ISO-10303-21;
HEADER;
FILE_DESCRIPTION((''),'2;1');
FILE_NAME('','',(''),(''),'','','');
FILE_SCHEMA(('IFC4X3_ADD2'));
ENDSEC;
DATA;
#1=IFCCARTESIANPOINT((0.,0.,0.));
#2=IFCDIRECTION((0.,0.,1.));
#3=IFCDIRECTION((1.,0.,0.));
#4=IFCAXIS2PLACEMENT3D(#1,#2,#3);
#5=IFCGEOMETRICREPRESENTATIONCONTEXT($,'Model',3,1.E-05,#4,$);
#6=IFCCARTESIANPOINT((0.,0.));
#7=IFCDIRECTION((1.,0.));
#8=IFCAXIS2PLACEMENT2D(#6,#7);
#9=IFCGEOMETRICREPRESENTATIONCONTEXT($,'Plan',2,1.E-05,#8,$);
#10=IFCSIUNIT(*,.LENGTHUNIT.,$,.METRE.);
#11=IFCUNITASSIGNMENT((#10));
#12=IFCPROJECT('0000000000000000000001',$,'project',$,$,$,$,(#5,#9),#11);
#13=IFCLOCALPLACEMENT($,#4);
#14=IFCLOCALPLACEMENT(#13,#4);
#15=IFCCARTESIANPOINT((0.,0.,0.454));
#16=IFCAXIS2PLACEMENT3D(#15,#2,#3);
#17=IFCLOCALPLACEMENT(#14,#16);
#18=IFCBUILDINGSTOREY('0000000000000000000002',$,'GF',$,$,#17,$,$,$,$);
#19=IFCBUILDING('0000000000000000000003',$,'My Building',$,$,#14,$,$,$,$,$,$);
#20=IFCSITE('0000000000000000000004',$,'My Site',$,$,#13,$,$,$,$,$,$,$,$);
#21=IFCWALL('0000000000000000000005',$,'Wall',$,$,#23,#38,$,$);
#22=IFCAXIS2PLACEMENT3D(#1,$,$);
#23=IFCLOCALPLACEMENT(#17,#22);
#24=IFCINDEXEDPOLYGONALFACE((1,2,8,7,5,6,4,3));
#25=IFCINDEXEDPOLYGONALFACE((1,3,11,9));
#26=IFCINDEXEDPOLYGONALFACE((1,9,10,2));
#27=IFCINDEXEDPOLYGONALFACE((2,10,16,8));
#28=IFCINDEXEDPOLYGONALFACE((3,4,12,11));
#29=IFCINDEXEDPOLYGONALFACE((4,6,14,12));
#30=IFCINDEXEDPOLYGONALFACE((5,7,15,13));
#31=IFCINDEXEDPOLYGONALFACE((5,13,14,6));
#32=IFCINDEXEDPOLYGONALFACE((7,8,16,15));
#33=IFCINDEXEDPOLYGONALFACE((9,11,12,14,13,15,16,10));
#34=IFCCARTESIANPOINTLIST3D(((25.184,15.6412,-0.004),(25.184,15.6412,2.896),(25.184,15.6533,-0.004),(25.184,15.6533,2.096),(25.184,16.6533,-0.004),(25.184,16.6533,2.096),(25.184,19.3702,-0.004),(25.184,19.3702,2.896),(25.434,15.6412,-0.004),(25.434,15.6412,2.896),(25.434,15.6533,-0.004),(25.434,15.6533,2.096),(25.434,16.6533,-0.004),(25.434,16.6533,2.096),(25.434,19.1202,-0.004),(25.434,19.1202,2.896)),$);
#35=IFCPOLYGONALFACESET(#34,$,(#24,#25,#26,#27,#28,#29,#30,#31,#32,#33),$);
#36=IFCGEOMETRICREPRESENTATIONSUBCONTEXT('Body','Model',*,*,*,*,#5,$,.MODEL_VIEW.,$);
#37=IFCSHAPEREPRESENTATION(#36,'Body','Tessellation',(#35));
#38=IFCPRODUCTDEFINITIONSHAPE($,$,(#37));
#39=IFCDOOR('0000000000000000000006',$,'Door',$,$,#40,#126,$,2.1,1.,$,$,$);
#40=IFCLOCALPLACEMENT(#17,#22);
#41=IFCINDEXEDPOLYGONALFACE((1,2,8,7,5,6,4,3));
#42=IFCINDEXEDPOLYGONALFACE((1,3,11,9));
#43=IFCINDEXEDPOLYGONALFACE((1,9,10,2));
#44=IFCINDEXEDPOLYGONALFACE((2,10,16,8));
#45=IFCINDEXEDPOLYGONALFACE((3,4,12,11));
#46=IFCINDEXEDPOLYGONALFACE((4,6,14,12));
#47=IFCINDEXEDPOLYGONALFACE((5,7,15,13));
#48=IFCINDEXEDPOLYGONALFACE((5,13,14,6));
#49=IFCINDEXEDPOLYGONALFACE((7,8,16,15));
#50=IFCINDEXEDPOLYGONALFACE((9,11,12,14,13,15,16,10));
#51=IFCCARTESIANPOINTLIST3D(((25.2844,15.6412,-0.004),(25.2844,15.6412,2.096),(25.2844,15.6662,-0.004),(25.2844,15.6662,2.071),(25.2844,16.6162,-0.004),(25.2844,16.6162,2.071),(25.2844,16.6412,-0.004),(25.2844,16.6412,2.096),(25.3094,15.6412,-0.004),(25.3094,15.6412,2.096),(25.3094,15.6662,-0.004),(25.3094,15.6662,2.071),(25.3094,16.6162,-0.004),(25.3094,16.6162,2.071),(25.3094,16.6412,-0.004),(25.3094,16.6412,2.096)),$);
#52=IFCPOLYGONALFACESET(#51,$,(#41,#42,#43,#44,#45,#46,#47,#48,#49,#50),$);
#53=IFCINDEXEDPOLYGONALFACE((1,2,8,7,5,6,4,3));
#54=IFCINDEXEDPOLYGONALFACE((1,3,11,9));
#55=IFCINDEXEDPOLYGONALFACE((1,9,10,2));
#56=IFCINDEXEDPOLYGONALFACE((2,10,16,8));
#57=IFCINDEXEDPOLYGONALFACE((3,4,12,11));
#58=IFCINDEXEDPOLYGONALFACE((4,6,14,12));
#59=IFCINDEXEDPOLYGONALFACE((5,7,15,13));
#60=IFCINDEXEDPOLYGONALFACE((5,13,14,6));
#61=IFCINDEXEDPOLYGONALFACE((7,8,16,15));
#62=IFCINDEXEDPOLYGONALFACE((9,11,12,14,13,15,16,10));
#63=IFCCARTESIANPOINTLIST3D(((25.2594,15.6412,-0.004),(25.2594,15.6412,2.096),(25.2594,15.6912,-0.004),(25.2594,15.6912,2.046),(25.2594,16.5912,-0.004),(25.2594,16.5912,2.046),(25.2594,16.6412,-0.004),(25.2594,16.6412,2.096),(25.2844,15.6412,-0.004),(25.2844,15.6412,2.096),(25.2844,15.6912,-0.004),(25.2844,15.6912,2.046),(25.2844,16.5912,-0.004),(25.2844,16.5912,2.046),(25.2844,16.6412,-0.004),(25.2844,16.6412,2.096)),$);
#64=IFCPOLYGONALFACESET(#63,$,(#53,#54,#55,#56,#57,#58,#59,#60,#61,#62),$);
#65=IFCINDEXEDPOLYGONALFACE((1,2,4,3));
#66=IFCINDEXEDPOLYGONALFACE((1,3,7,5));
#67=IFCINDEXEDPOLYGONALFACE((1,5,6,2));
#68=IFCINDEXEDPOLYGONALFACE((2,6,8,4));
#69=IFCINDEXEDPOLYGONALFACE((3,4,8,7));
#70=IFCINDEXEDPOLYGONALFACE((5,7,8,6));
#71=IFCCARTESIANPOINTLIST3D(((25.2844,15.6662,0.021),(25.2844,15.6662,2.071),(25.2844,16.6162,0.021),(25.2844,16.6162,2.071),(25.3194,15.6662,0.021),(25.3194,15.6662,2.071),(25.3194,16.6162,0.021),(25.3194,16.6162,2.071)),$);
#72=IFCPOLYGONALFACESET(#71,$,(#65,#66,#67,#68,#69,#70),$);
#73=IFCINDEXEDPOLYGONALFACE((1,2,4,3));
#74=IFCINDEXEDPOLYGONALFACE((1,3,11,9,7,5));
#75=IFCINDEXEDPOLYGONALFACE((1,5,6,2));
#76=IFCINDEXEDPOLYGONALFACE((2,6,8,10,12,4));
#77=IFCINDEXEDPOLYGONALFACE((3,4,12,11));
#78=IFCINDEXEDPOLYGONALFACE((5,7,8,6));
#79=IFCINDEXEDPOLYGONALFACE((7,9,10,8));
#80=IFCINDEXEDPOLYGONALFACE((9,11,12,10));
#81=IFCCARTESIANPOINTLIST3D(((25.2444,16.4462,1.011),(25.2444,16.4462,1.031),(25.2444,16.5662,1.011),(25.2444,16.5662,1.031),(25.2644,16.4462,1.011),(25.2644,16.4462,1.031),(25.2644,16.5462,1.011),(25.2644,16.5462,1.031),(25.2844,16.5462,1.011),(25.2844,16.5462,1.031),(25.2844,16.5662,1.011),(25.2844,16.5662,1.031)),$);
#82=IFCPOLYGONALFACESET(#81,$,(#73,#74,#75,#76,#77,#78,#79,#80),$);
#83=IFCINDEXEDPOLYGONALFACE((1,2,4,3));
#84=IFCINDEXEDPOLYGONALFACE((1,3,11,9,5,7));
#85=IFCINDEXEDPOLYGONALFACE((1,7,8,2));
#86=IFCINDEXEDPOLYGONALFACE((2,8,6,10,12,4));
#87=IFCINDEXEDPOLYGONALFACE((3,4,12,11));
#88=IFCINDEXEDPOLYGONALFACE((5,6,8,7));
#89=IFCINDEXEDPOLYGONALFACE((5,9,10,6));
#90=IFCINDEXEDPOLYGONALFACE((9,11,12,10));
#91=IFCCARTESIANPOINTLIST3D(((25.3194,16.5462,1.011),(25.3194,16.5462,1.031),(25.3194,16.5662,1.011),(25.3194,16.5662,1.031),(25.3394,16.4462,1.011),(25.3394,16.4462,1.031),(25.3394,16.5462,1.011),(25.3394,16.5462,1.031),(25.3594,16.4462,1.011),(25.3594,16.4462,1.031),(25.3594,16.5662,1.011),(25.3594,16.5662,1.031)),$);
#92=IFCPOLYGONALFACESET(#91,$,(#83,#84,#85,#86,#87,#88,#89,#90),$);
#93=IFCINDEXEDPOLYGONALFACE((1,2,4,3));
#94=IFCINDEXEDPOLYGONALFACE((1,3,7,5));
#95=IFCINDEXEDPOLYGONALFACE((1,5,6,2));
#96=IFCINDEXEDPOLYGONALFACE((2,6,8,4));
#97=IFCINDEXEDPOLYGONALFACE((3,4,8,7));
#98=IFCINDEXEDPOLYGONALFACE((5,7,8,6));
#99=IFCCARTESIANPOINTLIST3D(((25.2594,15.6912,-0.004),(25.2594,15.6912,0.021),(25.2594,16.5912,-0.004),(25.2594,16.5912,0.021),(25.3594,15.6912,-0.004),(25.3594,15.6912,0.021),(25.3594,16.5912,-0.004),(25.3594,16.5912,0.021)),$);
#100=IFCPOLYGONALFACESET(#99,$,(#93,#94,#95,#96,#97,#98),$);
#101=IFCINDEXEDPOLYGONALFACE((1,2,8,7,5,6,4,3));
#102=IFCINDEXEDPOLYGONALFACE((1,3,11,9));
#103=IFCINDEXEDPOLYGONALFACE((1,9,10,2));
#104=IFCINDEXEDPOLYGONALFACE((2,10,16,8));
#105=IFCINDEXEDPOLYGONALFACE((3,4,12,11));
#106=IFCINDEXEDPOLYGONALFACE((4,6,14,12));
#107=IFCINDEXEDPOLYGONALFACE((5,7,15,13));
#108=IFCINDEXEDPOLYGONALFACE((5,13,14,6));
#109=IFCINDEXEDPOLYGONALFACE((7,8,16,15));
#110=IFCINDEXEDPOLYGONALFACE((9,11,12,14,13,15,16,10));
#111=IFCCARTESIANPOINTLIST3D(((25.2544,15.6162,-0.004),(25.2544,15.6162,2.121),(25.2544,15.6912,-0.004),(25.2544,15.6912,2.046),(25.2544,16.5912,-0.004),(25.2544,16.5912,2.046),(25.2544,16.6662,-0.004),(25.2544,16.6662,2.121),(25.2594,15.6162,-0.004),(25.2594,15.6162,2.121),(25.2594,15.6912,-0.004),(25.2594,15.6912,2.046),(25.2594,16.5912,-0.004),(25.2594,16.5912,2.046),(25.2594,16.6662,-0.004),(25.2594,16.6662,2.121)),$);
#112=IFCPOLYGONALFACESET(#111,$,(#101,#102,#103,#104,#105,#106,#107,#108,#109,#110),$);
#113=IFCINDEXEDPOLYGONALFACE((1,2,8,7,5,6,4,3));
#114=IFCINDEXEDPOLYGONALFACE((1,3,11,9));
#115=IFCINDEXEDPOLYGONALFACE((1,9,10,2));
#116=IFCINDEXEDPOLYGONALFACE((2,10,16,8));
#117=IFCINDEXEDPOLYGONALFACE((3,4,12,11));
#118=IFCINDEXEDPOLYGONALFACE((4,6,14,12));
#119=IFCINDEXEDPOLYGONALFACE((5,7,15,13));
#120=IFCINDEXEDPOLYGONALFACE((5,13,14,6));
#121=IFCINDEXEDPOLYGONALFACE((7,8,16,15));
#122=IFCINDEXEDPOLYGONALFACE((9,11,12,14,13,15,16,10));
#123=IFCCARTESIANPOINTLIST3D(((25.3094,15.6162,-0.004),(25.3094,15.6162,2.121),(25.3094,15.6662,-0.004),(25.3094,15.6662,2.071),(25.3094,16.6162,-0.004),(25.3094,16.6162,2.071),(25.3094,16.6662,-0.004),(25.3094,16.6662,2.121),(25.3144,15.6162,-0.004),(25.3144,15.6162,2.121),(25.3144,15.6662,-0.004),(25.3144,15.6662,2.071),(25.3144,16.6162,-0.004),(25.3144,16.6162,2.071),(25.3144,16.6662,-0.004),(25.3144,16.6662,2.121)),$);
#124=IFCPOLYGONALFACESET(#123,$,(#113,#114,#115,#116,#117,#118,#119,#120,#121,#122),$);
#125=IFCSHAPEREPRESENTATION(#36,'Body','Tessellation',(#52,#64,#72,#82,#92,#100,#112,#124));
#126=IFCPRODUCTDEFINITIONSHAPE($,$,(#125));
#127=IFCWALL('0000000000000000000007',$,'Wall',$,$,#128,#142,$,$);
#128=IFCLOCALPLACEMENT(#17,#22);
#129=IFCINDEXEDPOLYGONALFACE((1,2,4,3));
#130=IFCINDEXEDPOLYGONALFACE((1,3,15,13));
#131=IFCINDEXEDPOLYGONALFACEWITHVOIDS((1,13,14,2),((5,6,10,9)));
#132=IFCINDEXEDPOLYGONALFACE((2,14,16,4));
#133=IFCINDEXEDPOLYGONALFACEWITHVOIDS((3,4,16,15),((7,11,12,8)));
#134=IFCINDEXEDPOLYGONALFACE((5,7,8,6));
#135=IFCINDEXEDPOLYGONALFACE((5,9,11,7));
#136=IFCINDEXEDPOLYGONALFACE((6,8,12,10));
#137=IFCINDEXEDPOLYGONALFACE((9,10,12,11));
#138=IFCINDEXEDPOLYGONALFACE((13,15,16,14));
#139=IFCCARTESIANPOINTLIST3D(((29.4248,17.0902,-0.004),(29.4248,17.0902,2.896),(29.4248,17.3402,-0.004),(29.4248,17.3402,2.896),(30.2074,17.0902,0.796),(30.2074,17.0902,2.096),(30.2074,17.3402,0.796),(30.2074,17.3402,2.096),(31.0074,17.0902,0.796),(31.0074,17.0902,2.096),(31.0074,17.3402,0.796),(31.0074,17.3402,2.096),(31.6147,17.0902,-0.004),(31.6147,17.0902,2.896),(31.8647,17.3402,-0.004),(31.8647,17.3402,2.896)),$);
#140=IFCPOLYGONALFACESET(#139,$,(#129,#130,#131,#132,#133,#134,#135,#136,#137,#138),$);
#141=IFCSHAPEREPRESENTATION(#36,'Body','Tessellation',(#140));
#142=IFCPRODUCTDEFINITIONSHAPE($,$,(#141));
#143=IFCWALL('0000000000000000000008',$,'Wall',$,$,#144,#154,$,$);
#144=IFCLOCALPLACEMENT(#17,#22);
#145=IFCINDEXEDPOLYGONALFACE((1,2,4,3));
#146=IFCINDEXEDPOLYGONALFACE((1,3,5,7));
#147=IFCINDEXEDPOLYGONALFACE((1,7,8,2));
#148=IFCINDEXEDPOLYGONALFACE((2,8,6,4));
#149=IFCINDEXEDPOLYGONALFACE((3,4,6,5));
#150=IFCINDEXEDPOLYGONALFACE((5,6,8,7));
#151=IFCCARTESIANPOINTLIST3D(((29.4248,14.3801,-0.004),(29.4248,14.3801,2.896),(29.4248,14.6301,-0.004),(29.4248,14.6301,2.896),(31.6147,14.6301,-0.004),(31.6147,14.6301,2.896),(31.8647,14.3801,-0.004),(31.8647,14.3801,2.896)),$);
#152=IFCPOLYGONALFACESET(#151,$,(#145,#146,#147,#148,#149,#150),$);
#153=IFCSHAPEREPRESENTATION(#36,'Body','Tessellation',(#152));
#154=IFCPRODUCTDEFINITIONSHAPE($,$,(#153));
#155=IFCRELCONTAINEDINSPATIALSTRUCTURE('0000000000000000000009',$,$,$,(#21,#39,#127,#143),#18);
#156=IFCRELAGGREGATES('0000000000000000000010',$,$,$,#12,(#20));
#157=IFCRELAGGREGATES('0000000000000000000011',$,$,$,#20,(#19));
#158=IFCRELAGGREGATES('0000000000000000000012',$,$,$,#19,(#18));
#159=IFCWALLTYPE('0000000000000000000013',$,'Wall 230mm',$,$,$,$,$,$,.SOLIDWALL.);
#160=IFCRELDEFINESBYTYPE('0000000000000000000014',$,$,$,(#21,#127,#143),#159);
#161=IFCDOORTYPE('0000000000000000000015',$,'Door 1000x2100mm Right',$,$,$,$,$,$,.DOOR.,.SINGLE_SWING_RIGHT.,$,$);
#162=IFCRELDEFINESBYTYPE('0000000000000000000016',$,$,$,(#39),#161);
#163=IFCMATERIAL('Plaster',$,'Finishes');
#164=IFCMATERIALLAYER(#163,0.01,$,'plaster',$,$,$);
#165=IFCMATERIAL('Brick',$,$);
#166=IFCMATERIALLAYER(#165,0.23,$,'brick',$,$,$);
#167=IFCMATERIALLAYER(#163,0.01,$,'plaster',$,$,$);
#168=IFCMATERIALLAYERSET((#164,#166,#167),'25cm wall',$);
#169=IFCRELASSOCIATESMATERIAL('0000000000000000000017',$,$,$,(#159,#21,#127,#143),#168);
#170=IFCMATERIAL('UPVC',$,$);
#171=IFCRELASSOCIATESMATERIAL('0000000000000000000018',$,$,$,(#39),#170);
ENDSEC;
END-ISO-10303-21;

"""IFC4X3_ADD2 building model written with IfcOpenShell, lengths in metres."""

from ifc_helpers import new_model, entity, si_unit, frame, origin_with_axes, origin_2d_with_axis, place, context, subcontext, project, spatial, line, indexed_curve, outline, extrude, shape, source, transform, mapped, material, layer, layer_set, layer_usage, type_object, type_shapes, element, fill, save


model = new_model("IFC4X3_ADD2")

# Units and contexts
model_context = context("Model", 3, precision=1e-05, world=origin_with_axes())
plan_context = context("Plan", 2, precision=1e-05, world=origin_2d_with_axis())
body_context_1 = subcontext(model_context, "Body", "Model", "MODEL_VIEW")
body_context_2 = subcontext(plan_context, "Body", "Plan", "PLAN_VIEW")
ifc_project = project(units=[si_unit("LENGTHUNIT", "METRE")], contexts=[model_context, plan_context])

# Site, building, storey
site_placement = place(None, origin_with_axes())
site = spatial("IfcSite", under=ifc_project, at=site_placement, Name="My Site")
building_placement = place(site_placement, origin_with_axes())
building = spatial("IfcBuilding", under=site, at=building_placement, Name="My Building")
storey_placement = place(building_placement, frame((0.0, 0.0, 0.454), z_axis=(0.0, 0.0, 1.0), x_axis=(1.0, 0.0, 0.0)))
storey = spatial("IfcBuildingStorey", under=building, at=storey_placement, Name="GF")

# Shared definitions
ifc_material_1 = material(Name="UPVC")

# Shared definitions
ifc_material_2 = material(Name="Plaster", Category="Finishes")
ifc_layer_1 = layer(ifc_material_2, 0.01, Name="plaster")
ifc_material_3 = material(Name="Brick")
ifc_layer_2 = layer(ifc_material_3, 0.23, Name="brick")
ifc_layer_3 = layer(ifc_material_2, 0.01, Name="plaster")
ifc_layer_set_1 = layer_set([ifc_layer_1, ifc_layer_2, ifc_layer_3], Name="25cm wall")
wall_type_1 = type_object("IfcWallType", Name="Wall 230mm", PredefinedType="SOLIDWALL", material=ifc_layer_set_1)

# Wall, opening, door
ifc_layer_usage_1 = layer_usage(ifc_layer_set_1, "AXIS2", "POSITIVE", 0.0)
wall_1_placement = place(storey_placement, frame((25.434, 15.6412, -0.004), z_axis=(0.0, 0.0, 1.0), x_axis=(0.000001, 1.0, 0.0)))
wall_1 = element("IfcWall", 1, at=wall_1_placement, inside=storey, type_object=wall_type_1, material=ifc_layer_usage_1, Name="Wall", context=body_context_1, shape_type="SweptSolid", body=[
    extrude(outline(indexed_curve([(0.0, 0.0), (0.0, 0.25), (3.729, 0.25), (3.479, 0.0)], segments=[line(1, 2, 3, 4, 1)])), origin_with_axes(), (0.0, 0.0, 1.0), 2.9),
])
shared_shape_1 = source(origin_with_axes(), body_context_1, "Body", "SweptSolid", [
    extrude(outline(indexed_curve([(0.0, 0.0), (1.0, 0.0), (1.0, 2.1), (0.0, 2.1)], segments=[line(1, 2, 3, 4, 1)])), frame((0.0, -0.6, 0.0), z_axis=(0.0, -1.0, 0.0), x_axis=(1.0, 0.0, 0.0)), (0.0, 0.0, -1.0), 1.2),
])
opening_1_placement = place(wall_1_placement, frame((0.012, 0.0, 0.0), z_axis=(0.0, 0.0, 1.0), x_axis=(1.0, 0.0, 0.0)))
opening_1 = element("IfcOpeningElement", 2, at=opening_1_placement, cuts=wall_1, PredefinedType="OPENING", context=body_context_1, shape_type="MappedRepresentation", body=[
    mapped(shared_shape_1, transform((0.0, 0.0, 0.0), x_axis=(1.0, 0.0, 0.0), y_axis=(0.0, 1.0, 0.0), z_axis=(0.0, 0.0, 1.0), scale=1.0)),
])
door_type_1 = type_object("IfcDoorType", Name="Door 1000x2100mm Right", OperationType="SINGLE_SWING_RIGHT", PredefinedType="DOOR")
shared_shape_2 = source(origin_with_axes(), body_context_1, "Body", "SweptSolid", [
    extrude(outline(indexed_curve([(0.0, 0.0), (0.0, 2.1), (1.0, 2.1), (1.0, 0.0), (0.975, 0.0), (0.975, 2.075), (0.025, 2.075), (0.025, 0.0)], segments=[line(1, 2, 3, 4, 5, 6, 7, 8, 1)])), frame((0.0, 0.025, 0.0), z_axis=(0.0, -1.0, 0.0), x_axis=(1.0, 0.0, 0.0)), (0.0, 0.0, -1.0), 0.025),
    extrude(outline(indexed_curve([(0.0, 0.0), (0.0, 2.1), (1.0, 2.1), (1.0, 0.0), (0.95, 0.0), (0.95, 2.05), (0.05, 2.05), (0.05, 0.0)], segments=[line(1, 2, 3, 4, 5, 6, 7, 8, 1)])), frame((0.0, 0.0, 0.0), z_axis=(0.0, -1.0, 0.0), x_axis=(1.0, 0.0, 0.0)), (0.0, 0.0, -1.0), 0.025),
    extrude(outline(indexed_curve([(0.0, 0.0), (0.95, 0.0), (0.95, 0.035), (0.0, 0.035)], segments=[line(1, 2, 3, 4, 1)])), frame((0.025, 0.025, 0.025), z_axis=(0.0, 0.0, 1.0), x_axis=(1.0, 0.0, 0.0)), (0.0, 0.0, 1.0), 2.05),
    extrude(outline(indexed_curve([(0.0, 0.0), (0.0, -0.04), (0.12, -0.04), (0.12, -0.02), (0.02, -0.02), (0.02, 0.0)], segments=[line(1, 2, 3, 4, 5, 6, 1)])), frame((0.075, 0.025, 1.015), z_axis=(0.0, 0.0, 1.0), x_axis=(1.0, 0.0, 0.0)), (0.0, 0.0, 1.0), 0.02),
    extrude(outline(indexed_curve([(0.0, 0.0), (0.0, 0.04), (0.12, 0.04), (0.12, 0.02), (0.02, 0.02), (0.02, 0.0)], segments=[line(1, 2, 3, 4, 5, 6, 1)])), frame((0.075, 0.06, 1.015), z_axis=(0.0, 0.0, 1.0), x_axis=(1.0, 0.0, 0.0)), (0.0, 0.0, 1.0), 0.02),
    extrude(outline(indexed_curve([(0.0, 0.0), (0.9, 0.0), (0.9, 0.1), (0.0, 0.1)], segments=[line(1, 2, 3, 4, 1)])), frame((0.05, 0.0, 0.0), z_axis=(0.0, 0.0, 1.0), x_axis=(1.0, 0.0, 0.0)), (0.0, 0.0, 1.0), 0.025),
    extrude(outline(indexed_curve([(0.0, 0.0), (0.0, 2.125), (1.05, 2.125), (1.05, 0.0), (0.975, 0.0), (0.975, 2.05), (0.075, 2.05), (0.075, 0.0)], segments=[line(1, 2, 3, 4, 5, 6, 7, 8, 1)])), frame((-0.025, -0.005, 0.0), z_axis=(0.0, -1.0, 0.0), x_axis=(1.0, 0.0, 0.0)), (0.0, 0.0, -1.0), 0.005),
    extrude(outline(indexed_curve([(0.0, 0.0), (0.0, 2.125), (1.05, 2.125), (1.05, 0.0), (1.0, 0.0), (1.0, 2.075), (0.05, 2.075), (0.05, 0.0)], segments=[line(1, 2, 3, 4, 5, 6, 7, 8, 1)])), frame((-0.025, 0.05, 0.0), z_axis=(0.0, -1.0, 0.0), x_axis=(1.0, 0.0, 0.0)), (0.0, 0.0, -1.0), 0.005),
])
shared_shape_3 = source(origin_with_axes(), body_context_2, "Body", "Curve2D", [
    entity("IfcIndexedPolyCurve", entity("IfcCartesianPointList2D", [[0.0, 0.0], [0.0, 0.05], [0.025, 0.05], [0.025, 0.025], [0.05, 0.025], [0.05, 0.0]]), [entity("IfcLineIndex", [1, 2, 3, 4, 5, 6, 1])]),
    entity("IfcIndexedPolyCurve", entity("IfcCartesianPointList2D", [[1.0, 0.0], [1.0, 0.05], [0.975, 0.05], [0.975, 0.025], [0.95, 0.025], [0.95, 0.0]]), [entity("IfcLineIndex", [1, 2, 3, 4, 5, 6, 1])]),
    entity("IfcTrimmedCurve", entity("IfcEllipse", entity("IfcAxis2Placement2D", entity("IfcCartesianPoint", [0.94, 0.05]), entity("IfcDirection", [1.0, 0.0])), 0.915, 0.95), [entity("IfcCartesianPoint", [0.94, 1.0])], [entity("IfcCartesianPoint", [0.025, 0.05])], True, "CARTESIAN"),
    entity("IfcIndexedPolyCurve", entity("IfcCartesianPointList2D", [[0.975, 0.05], [0.94, 0.05], [0.94, 1.0], [0.975, 1.0]]), [entity("IfcLineIndex", [1, 2, 3, 4, 1])]),
])
type_shapes(door_type_1, [shared_shape_2, shared_shape_3])
door_1_placement = place(opening_1_placement, frame((0.988, 0.1746, 0.0), z_axis=(0.0, 0.0, 1.0), x_axis=(-1.0, 0.0, 0.0)))
door_1 = element("IfcDoor", 3, at=door_1_placement, inside=storey, type_object=door_type_1, material=ifc_material_1, Name="Door", OverallHeight=2.1, OverallWidth=1.0, shapes=[
    shape(body_context_1, "Body", "MappedRepresentation", [mapped(shared_shape_2, transform((0.0, 0.0, 0.0), x_axis=(1.0, 0.0, 0.0), y_axis=(0.0, 1.0, 0.0), z_axis=(0.0, 0.0, 1.0), scale=1.0))]),
    shape(body_context_2, "Body", "MappedRepresentation", [mapped(shared_shape_3, transform((0.0, 0.0, 0.0), x_axis=(1.0, 0.0, 0.0), y_axis=(0.0, 1.0, 0.0), z_axis=(0.0, 0.0, 1.0), scale=1.0))]),
])
fill(opening_1, door_1)

# Wall, opening
ifc_layer_usage_2 = layer_usage(ifc_layer_set_1, "AXIS2", "POSITIVE", 0.0)
wall_2_placement = place(storey_placement, frame((31.8647, 17.3402, -0.004), z_axis=(0.0, 0.0, 1.0), x_axis=(-1.0, 0.0, 0.0)))
wall_2 = element("IfcWall", 4, at=wall_2_placement, inside=storey, type_object=wall_type_1, material=ifc_layer_usage_2, Name="Wall", context=body_context_1, shape_type="SweptSolid", body=[
    extrude(outline(indexed_curve([(0.0, 0.0), (0.25, 0.25), (2.44, 0.25), (2.44, 0.0)], segments=[line(1, 2, 3, 4, 1)])), origin_with_axes(), (0.0, 0.0, 1.0), 2.9),
])
shared_shape_4 = source(origin_with_axes(), body_context_1, "Body", "SweptSolid", [
    extrude(outline(indexed_curve([(0.0, 0.0), (0.8, 0.0), (0.8, 1.3), (0.0, 1.3)], segments=[line(1, 2, 3, 4, 1)])), frame((-0.4, -0.6, 0.0), z_axis=(0.0, -1.0, 0.0), x_axis=(1.0, 0.0, 0.0)), (0.0, 0.0, -1.0), 1.2),
])
opening_2_placement = place(wall_2_placement, frame((1.2573, 0.0, 0.8), z_axis=(0.0, 0.0, 1.0), x_axis=(1.0, 0.0, 0.0)))
element("IfcOpeningElement", 5, at=opening_2_placement, cuts=wall_2, PredefinedType="OPENING", context=body_context_1, shape_type="MappedRepresentation", body=[
    mapped(shared_shape_4, transform((0.0, 0.0, 0.0), x_axis=(1.0, 0.0, 0.0), y_axis=(0.0, 1.0, 0.0), z_axis=(0.0, 0.0, 1.0), scale=1.0)),
])

# Wall
ifc_layer_usage_3 = layer_usage(ifc_layer_set_1, "AXIS2", "NEGATIVE", 0.0)
wall_3_placement = place(storey_placement, frame((31.8647, 14.3801, -0.004), z_axis=(0.0, 0.0, 1.0), x_axis=(-1.0, 0.0, 0.0)))
element("IfcWall", 6, at=wall_3_placement, inside=storey, type_object=wall_type_1, material=ifc_layer_usage_3, Name="Wall", context=body_context_1, shape_type="SweptSolid", body=[
    extrude(outline(indexed_curve([(0.25, -0.25), (0.0, 0.0), (2.44, 0.0), (2.44, -0.25)], segments=[line(1, 2, 3, 4, 1)])), origin_with_axes(), (0.0, 0.0, 1.0), 2.9),
])

save(model, "model.ifc")
